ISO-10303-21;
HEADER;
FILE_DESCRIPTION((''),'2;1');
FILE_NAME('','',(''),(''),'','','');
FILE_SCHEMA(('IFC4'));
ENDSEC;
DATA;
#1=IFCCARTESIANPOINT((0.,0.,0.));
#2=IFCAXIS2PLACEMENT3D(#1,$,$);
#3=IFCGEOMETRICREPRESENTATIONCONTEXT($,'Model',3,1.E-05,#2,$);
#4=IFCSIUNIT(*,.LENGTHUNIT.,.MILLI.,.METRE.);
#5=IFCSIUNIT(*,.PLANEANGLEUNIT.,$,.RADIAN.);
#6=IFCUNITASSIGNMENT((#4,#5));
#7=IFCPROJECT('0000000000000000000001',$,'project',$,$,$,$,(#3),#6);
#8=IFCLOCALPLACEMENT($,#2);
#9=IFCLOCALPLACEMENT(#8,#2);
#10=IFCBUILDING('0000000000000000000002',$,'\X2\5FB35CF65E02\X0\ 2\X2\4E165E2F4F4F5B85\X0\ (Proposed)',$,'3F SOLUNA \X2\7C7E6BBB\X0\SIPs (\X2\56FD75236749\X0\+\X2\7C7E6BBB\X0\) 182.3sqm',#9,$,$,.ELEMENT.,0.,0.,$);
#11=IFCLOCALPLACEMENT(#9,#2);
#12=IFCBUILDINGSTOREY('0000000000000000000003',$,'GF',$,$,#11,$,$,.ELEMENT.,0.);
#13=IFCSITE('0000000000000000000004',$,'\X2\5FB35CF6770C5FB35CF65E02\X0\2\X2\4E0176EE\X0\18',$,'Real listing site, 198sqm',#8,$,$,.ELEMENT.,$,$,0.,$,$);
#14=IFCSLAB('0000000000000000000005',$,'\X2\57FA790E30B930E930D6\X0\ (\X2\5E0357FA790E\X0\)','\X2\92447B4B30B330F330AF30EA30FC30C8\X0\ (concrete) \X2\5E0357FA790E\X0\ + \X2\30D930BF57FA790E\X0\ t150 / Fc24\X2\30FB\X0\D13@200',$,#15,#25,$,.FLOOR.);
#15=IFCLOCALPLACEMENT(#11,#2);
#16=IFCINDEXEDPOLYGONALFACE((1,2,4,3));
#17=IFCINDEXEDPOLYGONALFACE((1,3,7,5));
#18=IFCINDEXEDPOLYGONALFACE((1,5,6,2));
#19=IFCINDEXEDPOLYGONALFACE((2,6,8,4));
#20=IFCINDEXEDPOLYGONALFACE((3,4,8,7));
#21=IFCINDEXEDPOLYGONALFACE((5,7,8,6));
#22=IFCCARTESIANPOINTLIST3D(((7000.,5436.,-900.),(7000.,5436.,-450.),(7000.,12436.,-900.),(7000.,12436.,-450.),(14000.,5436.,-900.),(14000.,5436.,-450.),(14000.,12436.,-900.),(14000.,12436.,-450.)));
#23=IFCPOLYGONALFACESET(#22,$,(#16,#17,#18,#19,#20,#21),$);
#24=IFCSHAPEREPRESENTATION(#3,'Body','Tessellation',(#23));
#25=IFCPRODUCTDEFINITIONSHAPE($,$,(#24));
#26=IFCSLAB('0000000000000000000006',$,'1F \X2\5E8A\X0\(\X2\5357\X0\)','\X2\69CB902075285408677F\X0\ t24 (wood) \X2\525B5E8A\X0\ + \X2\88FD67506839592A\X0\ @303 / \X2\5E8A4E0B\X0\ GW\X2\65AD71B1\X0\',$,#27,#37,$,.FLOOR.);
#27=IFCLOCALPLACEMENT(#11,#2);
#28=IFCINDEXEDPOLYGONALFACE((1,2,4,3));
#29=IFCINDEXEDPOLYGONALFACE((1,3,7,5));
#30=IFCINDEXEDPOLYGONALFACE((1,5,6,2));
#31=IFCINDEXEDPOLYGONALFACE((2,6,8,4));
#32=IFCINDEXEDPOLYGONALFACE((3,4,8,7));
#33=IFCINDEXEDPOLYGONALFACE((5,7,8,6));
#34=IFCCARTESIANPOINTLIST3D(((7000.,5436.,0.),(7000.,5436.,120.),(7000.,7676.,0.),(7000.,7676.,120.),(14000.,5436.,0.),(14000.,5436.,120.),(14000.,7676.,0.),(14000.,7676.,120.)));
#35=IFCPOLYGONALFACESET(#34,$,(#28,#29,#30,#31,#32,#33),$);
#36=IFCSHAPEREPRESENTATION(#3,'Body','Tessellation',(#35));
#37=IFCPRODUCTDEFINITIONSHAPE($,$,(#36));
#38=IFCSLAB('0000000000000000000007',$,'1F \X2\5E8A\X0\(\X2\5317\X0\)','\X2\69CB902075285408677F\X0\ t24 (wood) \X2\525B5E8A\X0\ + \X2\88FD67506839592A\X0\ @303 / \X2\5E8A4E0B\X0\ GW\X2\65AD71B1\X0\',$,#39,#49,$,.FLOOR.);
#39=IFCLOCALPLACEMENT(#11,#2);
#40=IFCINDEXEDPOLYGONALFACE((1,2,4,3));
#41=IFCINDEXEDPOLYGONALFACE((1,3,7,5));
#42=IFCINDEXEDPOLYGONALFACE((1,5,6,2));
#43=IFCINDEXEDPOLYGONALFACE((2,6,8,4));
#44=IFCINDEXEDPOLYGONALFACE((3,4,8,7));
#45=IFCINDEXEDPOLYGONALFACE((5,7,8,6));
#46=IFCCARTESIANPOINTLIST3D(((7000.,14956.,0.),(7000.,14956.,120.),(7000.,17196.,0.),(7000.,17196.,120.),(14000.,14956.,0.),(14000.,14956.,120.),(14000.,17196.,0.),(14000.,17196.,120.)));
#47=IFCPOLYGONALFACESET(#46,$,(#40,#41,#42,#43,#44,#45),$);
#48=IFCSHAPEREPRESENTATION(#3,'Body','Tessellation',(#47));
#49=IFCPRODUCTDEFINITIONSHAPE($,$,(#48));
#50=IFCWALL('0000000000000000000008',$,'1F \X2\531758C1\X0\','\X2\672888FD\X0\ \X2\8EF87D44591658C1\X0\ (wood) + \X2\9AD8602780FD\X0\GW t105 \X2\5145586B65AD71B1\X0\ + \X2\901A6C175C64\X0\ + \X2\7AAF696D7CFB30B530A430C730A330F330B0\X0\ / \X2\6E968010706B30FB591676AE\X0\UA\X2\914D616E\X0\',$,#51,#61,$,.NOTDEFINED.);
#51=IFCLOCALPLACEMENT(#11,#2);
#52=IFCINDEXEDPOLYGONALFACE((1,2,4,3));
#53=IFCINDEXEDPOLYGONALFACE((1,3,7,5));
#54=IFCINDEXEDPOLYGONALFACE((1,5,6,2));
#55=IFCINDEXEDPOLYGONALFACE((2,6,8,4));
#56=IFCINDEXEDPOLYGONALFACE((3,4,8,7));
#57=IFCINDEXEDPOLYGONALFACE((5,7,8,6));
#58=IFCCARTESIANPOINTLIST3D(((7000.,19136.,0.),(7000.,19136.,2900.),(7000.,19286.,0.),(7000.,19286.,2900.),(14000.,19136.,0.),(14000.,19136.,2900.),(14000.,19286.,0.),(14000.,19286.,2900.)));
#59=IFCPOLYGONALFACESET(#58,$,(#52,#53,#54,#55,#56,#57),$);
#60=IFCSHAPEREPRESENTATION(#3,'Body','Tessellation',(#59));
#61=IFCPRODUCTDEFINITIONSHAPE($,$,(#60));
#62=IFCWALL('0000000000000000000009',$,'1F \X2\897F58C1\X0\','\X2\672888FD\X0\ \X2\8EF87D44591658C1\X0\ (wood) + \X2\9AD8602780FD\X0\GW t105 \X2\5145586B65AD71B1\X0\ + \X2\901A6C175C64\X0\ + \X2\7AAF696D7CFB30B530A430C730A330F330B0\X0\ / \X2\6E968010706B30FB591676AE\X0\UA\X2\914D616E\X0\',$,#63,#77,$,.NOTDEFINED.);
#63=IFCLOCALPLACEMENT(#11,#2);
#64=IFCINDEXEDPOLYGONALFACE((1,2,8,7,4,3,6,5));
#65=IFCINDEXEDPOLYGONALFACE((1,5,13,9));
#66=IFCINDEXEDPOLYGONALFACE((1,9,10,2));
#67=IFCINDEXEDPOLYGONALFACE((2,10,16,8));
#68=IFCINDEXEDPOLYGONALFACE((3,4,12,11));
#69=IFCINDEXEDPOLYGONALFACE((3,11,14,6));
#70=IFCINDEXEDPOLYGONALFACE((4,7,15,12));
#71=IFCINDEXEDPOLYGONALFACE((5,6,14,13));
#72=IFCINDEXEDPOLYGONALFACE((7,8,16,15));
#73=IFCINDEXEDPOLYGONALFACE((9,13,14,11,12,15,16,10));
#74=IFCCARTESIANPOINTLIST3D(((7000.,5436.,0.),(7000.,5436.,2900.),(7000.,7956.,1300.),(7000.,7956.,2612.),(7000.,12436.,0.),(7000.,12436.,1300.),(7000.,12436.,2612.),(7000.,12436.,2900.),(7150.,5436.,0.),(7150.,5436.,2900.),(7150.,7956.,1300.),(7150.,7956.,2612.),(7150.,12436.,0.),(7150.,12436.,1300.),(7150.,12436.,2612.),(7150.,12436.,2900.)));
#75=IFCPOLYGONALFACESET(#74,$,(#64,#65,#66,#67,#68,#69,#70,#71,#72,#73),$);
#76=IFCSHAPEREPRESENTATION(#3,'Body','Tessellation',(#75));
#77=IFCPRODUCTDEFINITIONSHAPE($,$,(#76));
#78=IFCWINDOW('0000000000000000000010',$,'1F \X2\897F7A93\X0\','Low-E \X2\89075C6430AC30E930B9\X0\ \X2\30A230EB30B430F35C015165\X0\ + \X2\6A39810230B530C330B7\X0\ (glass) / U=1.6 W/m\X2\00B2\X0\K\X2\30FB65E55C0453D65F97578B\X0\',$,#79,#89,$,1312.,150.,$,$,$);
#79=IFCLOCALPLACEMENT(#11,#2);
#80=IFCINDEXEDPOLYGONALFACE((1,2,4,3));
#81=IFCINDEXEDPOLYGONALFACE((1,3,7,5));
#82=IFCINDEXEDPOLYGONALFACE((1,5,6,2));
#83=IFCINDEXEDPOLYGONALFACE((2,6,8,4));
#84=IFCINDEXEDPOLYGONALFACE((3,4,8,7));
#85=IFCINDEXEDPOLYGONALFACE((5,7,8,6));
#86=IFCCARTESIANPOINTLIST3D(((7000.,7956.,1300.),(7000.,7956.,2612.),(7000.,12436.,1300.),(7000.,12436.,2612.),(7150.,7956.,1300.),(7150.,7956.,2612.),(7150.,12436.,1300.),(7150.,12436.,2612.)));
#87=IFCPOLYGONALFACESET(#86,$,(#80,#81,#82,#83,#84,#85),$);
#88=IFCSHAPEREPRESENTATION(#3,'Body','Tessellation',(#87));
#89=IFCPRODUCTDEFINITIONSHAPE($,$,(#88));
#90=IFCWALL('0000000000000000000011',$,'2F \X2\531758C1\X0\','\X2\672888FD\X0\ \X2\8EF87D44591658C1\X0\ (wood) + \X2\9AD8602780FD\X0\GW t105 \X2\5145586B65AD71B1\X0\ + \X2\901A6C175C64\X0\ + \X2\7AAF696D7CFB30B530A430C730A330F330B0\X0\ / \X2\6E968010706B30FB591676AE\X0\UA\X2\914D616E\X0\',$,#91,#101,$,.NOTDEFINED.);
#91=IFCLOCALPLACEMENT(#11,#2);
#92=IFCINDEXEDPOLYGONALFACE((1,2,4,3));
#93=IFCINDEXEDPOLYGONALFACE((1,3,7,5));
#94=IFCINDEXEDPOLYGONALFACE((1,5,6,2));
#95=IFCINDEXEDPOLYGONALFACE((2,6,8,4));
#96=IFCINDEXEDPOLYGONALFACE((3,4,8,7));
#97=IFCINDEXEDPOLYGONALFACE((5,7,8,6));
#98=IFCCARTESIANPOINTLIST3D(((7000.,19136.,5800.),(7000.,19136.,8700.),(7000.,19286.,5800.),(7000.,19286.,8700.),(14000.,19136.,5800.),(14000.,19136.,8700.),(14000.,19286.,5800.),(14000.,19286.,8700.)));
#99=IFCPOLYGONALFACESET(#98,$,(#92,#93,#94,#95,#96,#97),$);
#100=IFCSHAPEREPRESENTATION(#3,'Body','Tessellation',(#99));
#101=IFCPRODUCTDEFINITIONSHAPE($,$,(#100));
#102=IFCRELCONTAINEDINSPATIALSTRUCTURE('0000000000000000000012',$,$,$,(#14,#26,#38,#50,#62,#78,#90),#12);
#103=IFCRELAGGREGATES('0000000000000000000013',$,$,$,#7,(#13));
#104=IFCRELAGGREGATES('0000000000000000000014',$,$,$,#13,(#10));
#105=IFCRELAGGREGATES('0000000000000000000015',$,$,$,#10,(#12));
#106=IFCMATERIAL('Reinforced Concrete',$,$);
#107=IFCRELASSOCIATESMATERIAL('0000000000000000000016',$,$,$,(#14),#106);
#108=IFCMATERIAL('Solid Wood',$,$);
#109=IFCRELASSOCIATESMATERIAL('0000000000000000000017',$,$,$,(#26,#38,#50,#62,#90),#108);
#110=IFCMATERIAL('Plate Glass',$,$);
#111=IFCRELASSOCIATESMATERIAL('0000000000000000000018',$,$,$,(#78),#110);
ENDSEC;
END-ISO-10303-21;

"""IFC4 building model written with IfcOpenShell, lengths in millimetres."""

from ifc_helpers import new_model, si_unit, frame, frame_2d, origin, place, context, project, spatial, rectangle, extrude, material, element, fill, save


model = new_model("IFC4")

# Units and contexts
model_context = context("Model", 3, precision=1e-05, world=origin())
ifc_project = project(units=[si_unit("LENGTHUNIT", "METRE", prefix="MILLI"), si_unit("PLANEANGLEUNIT", "RADIAN")], contexts=[model_context])

# Site, building, storey
site_placement = place(None, origin())
site = spatial("IfcSite", under=ifc_project, at=site_placement, Name="徳島県徳島市2丁目18", ObjectType="Real listing site, 198sqm", CompositionType="ELEMENT", RefElevation=0.0)
building_placement = place(site_placement, origin())
building = spatial("IfcBuilding", under=site, at=building_placement, Name="徳島市 2世帯住宅 (Proposed)", ObjectType="3F SOLUNA 籾殻SIPs (国産杉+籾殻) 182.3sqm", CompositionType="ELEMENT", ElevationOfRefHeight=0.0, ElevationOfTerrain=0.0)
storey_placement = place(building_placement, origin())
storey = spatial("IfcBuildingStorey", under=building, at=storey_placement, Name="GF", CompositionType="ELEMENT", Elevation=0.0)

# Slabs
ifc_material_1 = material(Name="Reinforced Concrete")
slab_1_placement = place(storey_placement, frame((3500.0, 2718.0, -450.0)))
element("IfcSlab", 1, at=slab_1_placement, inside=storey, material=ifc_material_1, Name="基礎スラブ (布基礎)", Description="鉄筋コンクリート (concrete) 布基礎 + ベタ基礎 t150 / Fc24・D13@200", PredefinedType="FLOOR", context=model_context, shape_type="SweptSolid", body=[
    extrude(rectangle(XDim=7000.0, YDim=7000.0, at=frame_2d((3500.0, 3500.0))), frame((3500.0, 2718.0, -450.0)), (0.0, 0.0, 1.0), 450.0),
])
ifc_material_2 = material(Name="Solid Wood")
slab_2_placement = place(storey_placement, frame((3500.0, 2718.0, 0.0)))
element("IfcSlab", 2, at=slab_2_placement, inside=storey, material=ifc_material_2, Name="1F 床(南)", Description="構造用合板 t24 (wood) 剛床 + 製材根太 @303 / 床下 GW断熱", PredefinedType="FLOOR", context=model_context, shape_type="SweptSolid", body=[
    extrude(rectangle(XDim=7000.0, YDim=2240.0, at=frame_2d((3500.0, 1120.0))), frame((3500.0, 2718.0, 0.0)), (0.0, 0.0, 1.0), 120.0),
])
slab_3_placement = place(storey_placement, frame((3500.0, 7478.0, 0.0)))
element("IfcSlab", 3, at=slab_3_placement, inside=storey, material=ifc_material_2, Name="1F 床(北)", Description="構造用合板 t24 (wood) 剛床 + 製材根太 @303 / 床下 GW断熱", PredefinedType="FLOOR", context=model_context, shape_type="SweptSolid", body=[
    extrude(rectangle(XDim=7000.0, YDim=2240.0, at=frame_2d((3500.0, 1120.0))), frame((3500.0, 7478.0, 0.0)), (0.0, 0.0, 1.0), 120.0),
])

# Shared definitions
ifc_material_3 = material(Name="Plate Glass")

# Wall
wall_1_placement = place(storey_placement, frame((3500.0, 9568.0, 0.0)))
element("IfcWall", 4, at=wall_1_placement, inside=storey, material=ifc_material_2, Name="1F 北壁", Description="木製 軸組外壁 (wood) + 高性能GW t105 充填断熱 + 通気層 + 窯業系サイディング / 準耐火・外皮UA配慮", PredefinedType="NOTDEFINED", context=model_context, shape_type="SweptSolid", body=[
    extrude(rectangle(XDim=7000.0, YDim=150.0, at=frame_2d((3500.0, 75.0))), frame((3500.0, 9568.0, 0.0)), (0.0, 0.0, 1.0), 2900.0),
])

# Wall, opening, window
wall_2_placement = place(storey_placement, frame((3500.0, 2718.0, 0.0)))
wall_2 = element("IfcWall", 5, at=wall_2_placement, inside=storey, material=ifc_material_2, Name="1F 西壁", Description="木製 軸組外壁 (wood) + 高性能GW t105 充填断熱 + 通気層 + 窯業系サイディング / 準耐火・外皮UA配慮", PredefinedType="NOTDEFINED", context=model_context, shape_type="SweptSolid", body=[
    extrude(rectangle(XDim=150.0, YDim=7000.0, at=frame_2d((75.0, 3500.0))), frame((3500.0, 2718.0, 0.0)), (0.0, 0.0, 1.0), 2900.0),
])
opening_1_placement = place(storey_placement, frame((3500.0, 3978.0, 650.0)))
opening_1 = element("IfcOpeningElement", 6, at=opening_1_placement, cuts=wall_2, PredefinedType="NOTDEFINED", context=model_context, shape_type="SweptSolid", body=[
    extrude(rectangle(XDim=150.0, YDim=4480.0, at=frame_2d((75.0, 2240.0))), frame((3500.0, 3978.0, 650.0)), (0.0, 0.0, 1.0), 1312.0),
])
window_1_placement = place(storey_placement, frame((3500.0, 3978.0, 650.0)))
window_1 = element("IfcWindow", 7, at=window_1_placement, inside=storey, material=ifc_material_3, Name="1F 西窓", Description="Low-E 複層ガラス アルゴン封入 + 樹脂サッシ (glass) / U=1.6 W/m²K・日射取得型", OverallHeight=1312.0, OverallWidth=150.0, context=model_context, shape_type="SweptSolid", body=[
    extrude(rectangle(XDim=150.0, YDim=4480.0, at=frame_2d((75.0, 2240.0))), frame((3500.0, 3978.0, 650.0)), (0.0, 0.0, 1.0), 1312.0),
])
fill(opening_1, window_1)

# Wall
wall_3_placement = place(storey_placement, frame((3500.0, 9568.0, 2900.0)))
element("IfcWall", 8, at=wall_3_placement, inside=storey, material=ifc_material_2, Name="2F 北壁", Description="木製 軸組外壁 (wood) + 高性能GW t105 充填断熱 + 通気層 + 窯業系サイディング / 準耐火・外皮UA配慮", PredefinedType="NOTDEFINED", context=model_context, shape_type="SweptSolid", body=[
    extrude(rectangle(XDim=7000.0, YDim=150.0, at=frame_2d((3500.0, 75.0))), frame((3500.0, 9568.0, 2900.0)), (0.0, 0.0, 1.0), 2900.0),
])

save(model, "model.ifc")
